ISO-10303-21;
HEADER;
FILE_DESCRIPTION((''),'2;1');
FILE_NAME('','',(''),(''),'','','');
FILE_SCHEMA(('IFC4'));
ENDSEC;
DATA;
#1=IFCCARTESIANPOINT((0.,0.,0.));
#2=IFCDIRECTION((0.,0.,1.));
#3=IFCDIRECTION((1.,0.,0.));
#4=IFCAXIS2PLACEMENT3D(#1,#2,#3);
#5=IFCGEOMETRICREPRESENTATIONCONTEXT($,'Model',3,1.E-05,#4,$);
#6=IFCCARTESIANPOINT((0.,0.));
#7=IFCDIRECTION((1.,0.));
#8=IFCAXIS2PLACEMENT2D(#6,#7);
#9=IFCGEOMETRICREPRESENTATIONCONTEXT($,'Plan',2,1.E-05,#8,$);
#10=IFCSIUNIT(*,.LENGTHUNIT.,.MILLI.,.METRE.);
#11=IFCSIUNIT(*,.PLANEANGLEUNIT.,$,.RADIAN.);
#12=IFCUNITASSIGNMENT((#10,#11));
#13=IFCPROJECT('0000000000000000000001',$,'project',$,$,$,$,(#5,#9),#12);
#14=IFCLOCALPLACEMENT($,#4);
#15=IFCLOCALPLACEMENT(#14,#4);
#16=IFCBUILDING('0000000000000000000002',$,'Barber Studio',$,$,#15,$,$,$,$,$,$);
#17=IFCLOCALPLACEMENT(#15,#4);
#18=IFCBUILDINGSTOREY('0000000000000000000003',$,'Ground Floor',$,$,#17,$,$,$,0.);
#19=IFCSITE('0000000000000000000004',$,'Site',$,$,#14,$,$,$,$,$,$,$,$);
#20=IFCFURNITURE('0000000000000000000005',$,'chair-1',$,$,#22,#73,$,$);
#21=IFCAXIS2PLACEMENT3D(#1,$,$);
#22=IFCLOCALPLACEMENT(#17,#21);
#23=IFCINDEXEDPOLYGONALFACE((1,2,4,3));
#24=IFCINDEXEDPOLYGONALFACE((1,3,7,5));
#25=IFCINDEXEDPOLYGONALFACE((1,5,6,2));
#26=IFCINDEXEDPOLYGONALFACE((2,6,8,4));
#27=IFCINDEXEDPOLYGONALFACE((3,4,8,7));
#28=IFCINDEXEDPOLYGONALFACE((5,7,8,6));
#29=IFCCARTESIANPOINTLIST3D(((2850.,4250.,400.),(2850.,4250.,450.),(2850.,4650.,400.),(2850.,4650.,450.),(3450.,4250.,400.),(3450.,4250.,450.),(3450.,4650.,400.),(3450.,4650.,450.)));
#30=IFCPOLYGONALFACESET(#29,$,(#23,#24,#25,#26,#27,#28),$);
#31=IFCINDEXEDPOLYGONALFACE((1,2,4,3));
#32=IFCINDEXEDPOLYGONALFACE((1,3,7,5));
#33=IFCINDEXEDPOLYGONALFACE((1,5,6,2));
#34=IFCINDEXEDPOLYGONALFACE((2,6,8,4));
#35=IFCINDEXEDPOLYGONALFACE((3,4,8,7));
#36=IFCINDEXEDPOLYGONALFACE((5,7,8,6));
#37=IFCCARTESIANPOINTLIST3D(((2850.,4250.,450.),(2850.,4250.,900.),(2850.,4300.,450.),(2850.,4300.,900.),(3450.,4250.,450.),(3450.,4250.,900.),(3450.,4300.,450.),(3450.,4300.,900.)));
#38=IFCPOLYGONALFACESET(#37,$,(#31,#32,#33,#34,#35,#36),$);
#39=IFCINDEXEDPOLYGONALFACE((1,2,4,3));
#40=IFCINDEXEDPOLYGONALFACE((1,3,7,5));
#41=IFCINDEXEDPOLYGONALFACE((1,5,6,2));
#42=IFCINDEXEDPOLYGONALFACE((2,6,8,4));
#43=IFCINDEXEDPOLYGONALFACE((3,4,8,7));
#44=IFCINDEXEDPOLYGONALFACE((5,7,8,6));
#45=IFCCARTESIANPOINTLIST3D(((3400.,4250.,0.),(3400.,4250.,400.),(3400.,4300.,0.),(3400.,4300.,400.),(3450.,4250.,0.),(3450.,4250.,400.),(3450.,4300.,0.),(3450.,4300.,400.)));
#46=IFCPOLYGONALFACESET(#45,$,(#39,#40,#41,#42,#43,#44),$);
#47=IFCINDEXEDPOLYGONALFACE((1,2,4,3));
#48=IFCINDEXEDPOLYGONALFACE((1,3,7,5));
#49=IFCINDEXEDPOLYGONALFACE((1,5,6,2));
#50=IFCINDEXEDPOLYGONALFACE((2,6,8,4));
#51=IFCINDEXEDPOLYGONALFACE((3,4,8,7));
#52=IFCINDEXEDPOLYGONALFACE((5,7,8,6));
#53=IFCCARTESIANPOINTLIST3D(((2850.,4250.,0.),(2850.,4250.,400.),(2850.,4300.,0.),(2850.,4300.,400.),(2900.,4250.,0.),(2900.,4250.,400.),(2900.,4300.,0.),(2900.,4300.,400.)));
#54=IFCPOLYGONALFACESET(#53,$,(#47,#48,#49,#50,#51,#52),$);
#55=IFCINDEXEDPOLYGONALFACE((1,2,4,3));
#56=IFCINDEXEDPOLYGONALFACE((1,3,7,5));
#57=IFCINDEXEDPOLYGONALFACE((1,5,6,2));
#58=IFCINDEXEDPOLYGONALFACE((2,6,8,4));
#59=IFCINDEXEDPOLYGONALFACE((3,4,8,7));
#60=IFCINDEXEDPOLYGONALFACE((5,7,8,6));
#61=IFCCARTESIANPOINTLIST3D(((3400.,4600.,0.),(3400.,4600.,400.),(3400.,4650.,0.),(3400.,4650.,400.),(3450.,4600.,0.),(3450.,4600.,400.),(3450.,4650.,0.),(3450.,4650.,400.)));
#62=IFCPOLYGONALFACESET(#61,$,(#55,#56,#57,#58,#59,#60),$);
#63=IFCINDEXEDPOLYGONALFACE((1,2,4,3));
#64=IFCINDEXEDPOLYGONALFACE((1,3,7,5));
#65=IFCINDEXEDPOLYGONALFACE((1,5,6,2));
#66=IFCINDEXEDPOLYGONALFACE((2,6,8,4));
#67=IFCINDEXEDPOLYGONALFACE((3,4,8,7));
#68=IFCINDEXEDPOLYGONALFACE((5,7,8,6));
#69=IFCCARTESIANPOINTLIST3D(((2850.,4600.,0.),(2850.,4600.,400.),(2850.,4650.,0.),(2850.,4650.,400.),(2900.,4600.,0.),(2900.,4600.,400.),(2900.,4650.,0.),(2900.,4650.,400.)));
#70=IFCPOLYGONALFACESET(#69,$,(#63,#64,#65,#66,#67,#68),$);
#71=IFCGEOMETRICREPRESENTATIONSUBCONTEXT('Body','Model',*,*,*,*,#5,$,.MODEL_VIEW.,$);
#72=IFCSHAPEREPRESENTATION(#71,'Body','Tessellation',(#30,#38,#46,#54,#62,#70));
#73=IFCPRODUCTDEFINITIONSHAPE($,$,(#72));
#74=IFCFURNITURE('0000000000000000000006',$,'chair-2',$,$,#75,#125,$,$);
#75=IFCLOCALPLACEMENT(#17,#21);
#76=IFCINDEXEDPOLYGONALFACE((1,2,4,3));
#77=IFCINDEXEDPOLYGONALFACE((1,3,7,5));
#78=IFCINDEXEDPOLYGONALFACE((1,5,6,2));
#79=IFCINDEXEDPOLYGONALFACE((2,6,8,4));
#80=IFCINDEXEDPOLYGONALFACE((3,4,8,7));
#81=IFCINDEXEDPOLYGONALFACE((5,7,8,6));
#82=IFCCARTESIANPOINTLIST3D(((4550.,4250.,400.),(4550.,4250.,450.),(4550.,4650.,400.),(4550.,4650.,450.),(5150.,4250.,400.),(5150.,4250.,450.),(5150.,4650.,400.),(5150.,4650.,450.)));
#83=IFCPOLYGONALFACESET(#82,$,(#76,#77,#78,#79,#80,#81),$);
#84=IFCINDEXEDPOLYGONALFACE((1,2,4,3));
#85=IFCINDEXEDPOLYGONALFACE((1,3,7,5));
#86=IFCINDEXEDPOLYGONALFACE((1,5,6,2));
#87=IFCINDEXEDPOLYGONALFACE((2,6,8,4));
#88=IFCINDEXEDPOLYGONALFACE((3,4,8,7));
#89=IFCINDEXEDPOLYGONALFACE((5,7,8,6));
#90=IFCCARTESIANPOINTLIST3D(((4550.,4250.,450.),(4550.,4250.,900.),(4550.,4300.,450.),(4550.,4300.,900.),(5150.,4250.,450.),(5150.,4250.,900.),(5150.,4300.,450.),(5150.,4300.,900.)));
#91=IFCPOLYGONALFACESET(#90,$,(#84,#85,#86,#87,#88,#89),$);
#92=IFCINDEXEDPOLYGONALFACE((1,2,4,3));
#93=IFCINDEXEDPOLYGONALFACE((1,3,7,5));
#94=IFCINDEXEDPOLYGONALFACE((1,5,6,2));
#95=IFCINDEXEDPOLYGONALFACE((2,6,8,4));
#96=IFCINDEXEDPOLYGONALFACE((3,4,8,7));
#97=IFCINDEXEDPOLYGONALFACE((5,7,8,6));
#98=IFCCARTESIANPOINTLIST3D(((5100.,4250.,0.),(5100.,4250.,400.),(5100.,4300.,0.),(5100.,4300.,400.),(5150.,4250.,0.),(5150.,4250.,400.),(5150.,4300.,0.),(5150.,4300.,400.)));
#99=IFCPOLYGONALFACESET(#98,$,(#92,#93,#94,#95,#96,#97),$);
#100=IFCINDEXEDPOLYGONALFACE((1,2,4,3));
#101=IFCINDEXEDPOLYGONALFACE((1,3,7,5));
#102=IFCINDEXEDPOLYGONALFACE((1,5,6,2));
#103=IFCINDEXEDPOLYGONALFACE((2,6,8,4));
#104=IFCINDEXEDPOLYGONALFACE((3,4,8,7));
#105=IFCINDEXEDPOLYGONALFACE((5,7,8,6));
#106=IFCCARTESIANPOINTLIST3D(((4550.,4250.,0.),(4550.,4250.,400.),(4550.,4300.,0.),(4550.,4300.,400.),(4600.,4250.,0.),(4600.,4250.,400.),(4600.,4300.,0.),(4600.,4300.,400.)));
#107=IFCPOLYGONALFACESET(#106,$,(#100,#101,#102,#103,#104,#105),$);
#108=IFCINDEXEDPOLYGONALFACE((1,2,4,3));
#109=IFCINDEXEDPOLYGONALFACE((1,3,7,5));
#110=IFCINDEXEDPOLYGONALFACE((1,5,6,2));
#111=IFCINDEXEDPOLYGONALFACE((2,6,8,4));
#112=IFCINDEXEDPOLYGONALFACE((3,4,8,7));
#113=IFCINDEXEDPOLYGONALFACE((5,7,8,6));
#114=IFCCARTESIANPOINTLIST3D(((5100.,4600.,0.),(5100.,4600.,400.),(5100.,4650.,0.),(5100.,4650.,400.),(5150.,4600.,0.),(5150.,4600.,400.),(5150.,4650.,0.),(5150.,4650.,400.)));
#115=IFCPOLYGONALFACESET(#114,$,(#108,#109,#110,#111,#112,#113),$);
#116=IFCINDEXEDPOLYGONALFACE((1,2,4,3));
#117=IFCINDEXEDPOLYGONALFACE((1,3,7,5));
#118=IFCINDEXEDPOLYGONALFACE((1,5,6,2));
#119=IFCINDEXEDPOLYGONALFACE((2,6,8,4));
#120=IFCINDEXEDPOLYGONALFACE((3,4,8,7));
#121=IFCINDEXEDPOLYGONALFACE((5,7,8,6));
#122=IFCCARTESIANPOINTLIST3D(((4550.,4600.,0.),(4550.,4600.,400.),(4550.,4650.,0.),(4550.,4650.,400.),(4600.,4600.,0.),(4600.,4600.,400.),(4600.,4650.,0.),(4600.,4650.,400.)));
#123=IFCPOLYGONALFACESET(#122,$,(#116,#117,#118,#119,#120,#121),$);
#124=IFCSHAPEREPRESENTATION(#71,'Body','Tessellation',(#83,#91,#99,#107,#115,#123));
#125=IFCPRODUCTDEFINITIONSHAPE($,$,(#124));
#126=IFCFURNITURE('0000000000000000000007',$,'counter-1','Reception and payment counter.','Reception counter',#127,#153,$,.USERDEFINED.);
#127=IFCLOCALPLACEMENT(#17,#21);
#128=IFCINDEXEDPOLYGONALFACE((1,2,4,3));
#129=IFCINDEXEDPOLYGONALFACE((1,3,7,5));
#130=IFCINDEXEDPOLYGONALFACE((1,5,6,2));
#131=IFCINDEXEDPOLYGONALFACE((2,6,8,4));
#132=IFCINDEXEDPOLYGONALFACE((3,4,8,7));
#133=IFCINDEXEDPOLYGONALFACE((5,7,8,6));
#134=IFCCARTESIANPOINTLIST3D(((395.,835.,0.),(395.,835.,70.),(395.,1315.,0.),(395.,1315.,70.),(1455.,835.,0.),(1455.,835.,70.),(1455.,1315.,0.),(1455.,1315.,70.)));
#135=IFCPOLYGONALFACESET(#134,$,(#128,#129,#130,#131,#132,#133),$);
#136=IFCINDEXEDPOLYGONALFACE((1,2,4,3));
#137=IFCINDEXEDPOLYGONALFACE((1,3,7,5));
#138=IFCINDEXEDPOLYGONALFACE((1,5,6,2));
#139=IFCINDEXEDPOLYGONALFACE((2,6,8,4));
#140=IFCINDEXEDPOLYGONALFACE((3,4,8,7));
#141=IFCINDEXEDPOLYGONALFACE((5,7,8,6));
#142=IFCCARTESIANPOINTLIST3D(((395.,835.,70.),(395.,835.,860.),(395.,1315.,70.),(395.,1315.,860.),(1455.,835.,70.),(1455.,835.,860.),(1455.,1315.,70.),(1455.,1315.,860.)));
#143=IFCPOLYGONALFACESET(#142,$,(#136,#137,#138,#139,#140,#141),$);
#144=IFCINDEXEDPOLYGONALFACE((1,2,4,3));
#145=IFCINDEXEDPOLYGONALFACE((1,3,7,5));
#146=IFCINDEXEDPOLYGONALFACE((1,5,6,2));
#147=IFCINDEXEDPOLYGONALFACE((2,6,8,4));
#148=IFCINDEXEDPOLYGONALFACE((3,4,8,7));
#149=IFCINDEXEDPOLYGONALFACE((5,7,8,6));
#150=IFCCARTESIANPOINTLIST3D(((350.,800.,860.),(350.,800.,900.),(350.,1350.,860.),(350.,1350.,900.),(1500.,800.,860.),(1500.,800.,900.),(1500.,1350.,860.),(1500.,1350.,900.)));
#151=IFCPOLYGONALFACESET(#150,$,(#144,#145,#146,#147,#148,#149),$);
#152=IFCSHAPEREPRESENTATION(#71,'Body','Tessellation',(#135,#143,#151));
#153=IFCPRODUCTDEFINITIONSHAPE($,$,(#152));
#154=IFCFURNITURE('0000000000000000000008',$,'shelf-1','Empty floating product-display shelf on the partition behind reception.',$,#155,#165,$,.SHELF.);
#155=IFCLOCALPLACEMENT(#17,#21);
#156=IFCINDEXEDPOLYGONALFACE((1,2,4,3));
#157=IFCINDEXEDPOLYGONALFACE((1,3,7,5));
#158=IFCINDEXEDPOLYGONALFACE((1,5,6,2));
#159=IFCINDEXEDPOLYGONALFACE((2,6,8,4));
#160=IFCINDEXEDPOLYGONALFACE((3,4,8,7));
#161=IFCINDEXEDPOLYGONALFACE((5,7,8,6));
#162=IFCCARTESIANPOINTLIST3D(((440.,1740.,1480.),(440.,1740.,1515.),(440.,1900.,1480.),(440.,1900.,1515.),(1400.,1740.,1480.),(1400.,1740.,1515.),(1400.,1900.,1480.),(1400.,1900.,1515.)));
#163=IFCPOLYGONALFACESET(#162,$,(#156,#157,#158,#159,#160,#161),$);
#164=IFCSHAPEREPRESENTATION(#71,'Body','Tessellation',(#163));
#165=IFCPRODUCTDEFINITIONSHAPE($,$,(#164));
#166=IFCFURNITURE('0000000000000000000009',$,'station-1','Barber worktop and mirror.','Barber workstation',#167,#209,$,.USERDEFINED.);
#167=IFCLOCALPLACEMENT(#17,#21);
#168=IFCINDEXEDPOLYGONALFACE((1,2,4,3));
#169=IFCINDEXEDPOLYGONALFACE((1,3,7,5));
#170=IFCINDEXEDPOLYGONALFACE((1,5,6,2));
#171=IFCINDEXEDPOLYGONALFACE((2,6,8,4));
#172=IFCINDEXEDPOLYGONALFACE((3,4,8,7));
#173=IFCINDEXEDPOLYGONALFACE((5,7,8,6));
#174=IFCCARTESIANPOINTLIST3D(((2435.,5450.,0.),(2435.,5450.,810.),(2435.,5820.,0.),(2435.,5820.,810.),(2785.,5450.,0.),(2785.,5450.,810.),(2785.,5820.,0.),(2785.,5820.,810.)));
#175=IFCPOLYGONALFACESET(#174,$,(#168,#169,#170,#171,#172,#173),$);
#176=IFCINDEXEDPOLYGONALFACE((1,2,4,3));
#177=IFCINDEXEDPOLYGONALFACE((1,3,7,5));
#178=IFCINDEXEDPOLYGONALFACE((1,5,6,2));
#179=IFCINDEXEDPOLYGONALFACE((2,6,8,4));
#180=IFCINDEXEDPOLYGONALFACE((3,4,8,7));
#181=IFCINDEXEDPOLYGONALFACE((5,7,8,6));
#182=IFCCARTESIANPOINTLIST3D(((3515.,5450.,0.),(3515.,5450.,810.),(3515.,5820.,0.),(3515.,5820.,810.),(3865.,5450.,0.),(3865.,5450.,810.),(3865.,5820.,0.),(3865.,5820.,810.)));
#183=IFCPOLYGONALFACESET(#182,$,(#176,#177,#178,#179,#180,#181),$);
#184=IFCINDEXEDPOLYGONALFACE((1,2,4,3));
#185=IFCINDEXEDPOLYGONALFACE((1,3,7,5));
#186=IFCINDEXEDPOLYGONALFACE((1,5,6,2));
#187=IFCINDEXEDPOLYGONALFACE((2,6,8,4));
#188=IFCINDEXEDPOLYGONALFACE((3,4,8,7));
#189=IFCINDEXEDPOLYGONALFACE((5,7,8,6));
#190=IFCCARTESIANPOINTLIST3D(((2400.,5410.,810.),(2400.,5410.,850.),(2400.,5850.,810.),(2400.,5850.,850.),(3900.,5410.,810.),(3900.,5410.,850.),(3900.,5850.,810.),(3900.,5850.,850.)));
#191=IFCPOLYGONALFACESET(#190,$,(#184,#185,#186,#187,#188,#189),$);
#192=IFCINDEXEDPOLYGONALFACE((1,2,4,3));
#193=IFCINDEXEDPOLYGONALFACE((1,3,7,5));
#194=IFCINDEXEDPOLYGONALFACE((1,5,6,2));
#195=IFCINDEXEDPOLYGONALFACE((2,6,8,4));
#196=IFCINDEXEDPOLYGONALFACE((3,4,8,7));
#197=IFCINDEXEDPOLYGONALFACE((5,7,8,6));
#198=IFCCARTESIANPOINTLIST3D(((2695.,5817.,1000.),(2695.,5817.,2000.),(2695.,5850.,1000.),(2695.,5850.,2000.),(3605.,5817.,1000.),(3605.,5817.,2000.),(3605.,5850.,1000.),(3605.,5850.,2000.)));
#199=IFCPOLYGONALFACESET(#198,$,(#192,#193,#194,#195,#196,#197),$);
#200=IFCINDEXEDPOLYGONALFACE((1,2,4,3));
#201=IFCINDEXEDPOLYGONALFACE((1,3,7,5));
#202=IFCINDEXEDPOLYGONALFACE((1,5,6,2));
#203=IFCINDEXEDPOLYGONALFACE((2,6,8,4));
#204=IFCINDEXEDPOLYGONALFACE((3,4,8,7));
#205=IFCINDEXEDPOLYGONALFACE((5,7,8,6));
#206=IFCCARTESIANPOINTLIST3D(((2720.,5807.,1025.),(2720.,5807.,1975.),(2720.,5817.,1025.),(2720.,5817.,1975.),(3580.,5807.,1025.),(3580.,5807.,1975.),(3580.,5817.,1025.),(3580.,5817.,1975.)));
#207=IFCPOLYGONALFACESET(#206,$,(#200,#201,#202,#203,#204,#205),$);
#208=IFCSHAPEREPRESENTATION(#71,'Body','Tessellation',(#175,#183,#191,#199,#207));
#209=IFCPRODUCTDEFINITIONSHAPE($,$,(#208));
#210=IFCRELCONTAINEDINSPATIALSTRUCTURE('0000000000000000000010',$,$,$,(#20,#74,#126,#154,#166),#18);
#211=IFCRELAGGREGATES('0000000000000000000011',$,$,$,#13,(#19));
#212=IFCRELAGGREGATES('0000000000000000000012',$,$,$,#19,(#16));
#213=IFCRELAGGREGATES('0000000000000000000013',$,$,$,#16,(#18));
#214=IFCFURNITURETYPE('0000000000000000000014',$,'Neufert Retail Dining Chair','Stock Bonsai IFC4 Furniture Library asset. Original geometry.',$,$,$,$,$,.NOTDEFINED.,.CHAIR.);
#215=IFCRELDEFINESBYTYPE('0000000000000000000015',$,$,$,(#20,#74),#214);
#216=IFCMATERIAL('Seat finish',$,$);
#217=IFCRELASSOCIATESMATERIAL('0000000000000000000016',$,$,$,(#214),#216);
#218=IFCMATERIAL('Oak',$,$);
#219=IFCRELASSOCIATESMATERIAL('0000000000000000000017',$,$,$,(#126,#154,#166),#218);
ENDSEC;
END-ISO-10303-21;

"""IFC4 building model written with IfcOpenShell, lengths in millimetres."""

from ifc_helpers import new_model, entity, si_unit, frame, origin_with_axes, origin_2d_with_axis, place, context, subcontext, project, spatial, line, indexed_curve, outline, extrude, shape, source, transform, mapped, material, type_object, type_shapes, element, save


model = new_model("IFC4")

# Units and contexts
model_context = context("Model", 3, precision=1e-05, world=origin_with_axes())
plan_context = context("Plan", 2, precision=1e-05, world=origin_2d_with_axis())
body_context_1 = subcontext(model_context, "Body", "Model", "MODEL_VIEW")
body_context_2 = subcontext(plan_context, "Body", "Plan", "PLAN_VIEW")
ifc_project = project(units=[si_unit("LENGTHUNIT", "METRE", prefix="MILLI"), si_unit("PLANEANGLEUNIT", "RADIAN")], contexts=[model_context, plan_context])

# Site, building, storey
site_placement = place(None, origin_with_axes())
site = spatial("IfcSite", under=ifc_project, at=site_placement, Name="Site")
building_placement = place(site_placement, origin_with_axes())
building = spatial("IfcBuilding", under=site, at=building_placement, Name="Barber Studio")
storey_placement = place(building_placement, origin_with_axes())
storey = spatial("IfcBuildingStorey", under=building, at=storey_placement, Name="Ground Floor", Elevation=0.0)

# Furniture
ifc_material_1 = material(Name="Seat finish")
furniture_type_1 = type_object("IfcFurnitureType", Name="Neufert Retail Dining Chair", Description="Stock Bonsai IFC4 Furniture Library asset. Original geometry.", AssemblyPlace="NOTDEFINED", PredefinedType="CHAIR", material=ifc_material_1)
shared_shape_1 = source(origin_with_axes(), body_context_1, "Body", "SweptSolid", [
    extrude(outline(indexed_curve([(-300.0, 0.0), (300.0, 0.0), (300.0, -400.0), (-300.0, -400.0)], segments=[line(1, 2, 3, 4, 1)])), frame((0.0, 0.0, 450.0), z_axis=(0.0, 0.0, 1.0), x_axis=(1.0, 0.0, 0.0)), (0.0, 0.0, -1.0), 50.0),
    extrude(outline(indexed_curve([(-300.0, 0.0), (300.0, 0.0), (300.0, -50.0), (-300.0, -50.0)], segments=[line(1, 2, 3, 4, 1)])), frame((0.0, 0.0, 900.0), z_axis=(0.0, 0.0, 1.0), x_axis=(1.0, 0.0, 0.0)), (0.0, 0.0, -1.0), 450.0),
    extrude(outline(indexed_curve([(-300.0, 0.0), (-250.0, 0.0), (-250.0, -50.0), (-300.0, -50.0)], segments=[line(1, 2, 3, 4, 1)])), origin_with_axes(), (0.0, 0.0, 1.0), 400.0),
    extrude(outline(indexed_curve([(300.0, 0.0), (250.0, 0.0), (250.0, -50.0), (300.0, -50.0)], segments=[line(1, 2, 3, 4, 1)])), origin_with_axes(), (0.0, 0.0, 1.0), 400.0),
    extrude(outline(indexed_curve([(-300.0, -400.0), (-250.0, -400.0), (-250.0, -350.0), (-300.0, -350.0)], segments=[line(1, 2, 3, 4, 1)])), origin_with_axes(), (0.0, 0.0, 1.0), 400.0),
    extrude(outline(indexed_curve([(300.0, -400.0), (250.0, -400.0), (250.0, -350.0), (300.0, -350.0)], segments=[line(1, 2, 3, 4, 1)])), origin_with_axes(), (0.0, 0.0, 1.0), 400.0),
])
shared_shape_2 = source(origin_with_axes(), body_context_2, "Body", "Curve2D", [
    entity("IfcIndexedPolyCurve", entity("IfcCartesianPointList2D", [[-300.0, -400.0], [300.0, -400.0]])),
    entity("IfcIndexedPolyCurve", entity("IfcCartesianPointList2D", [[-300.0, -400.0], [-300.0, -300.0], [-212.1, -87.9], [0.0, 0.0], [212.1, -87.9], [300.0, -300.0], [300.0, -400.0]]), [entity("IfcLineIndex", [1, 2]), entity("IfcArcIndex", [2, 3, 4]), entity("IfcArcIndex", [4, 5, 6]), entity("IfcLineIndex", [6, 7])]),
    entity("IfcIndexedPolyCurve", entity("IfcCartesianPointList2D", [[-260.0, -400.0], [-260.0, -300.0], [-183.8, -116.2], [0.0, -40.0], [183.8, -116.2], [260.0, -300.0], [260.0, -400.0]]), [entity("IfcLineIndex", [1, 2]), entity("IfcArcIndex", [2, 3, 4]), entity("IfcArcIndex", [4, 5, 6]), entity("IfcLineIndex", [6, 7])]),
])
type_shapes(furniture_type_1, [shared_shape_1, shared_shape_2])
for number, where, z_axis, x_axis, name in (
    (1, (3150.0, 4250.0, 0.0), (0.0, 0.0, 1.0), (-1.0, 0.0, 0.0), "chair-1"),
    (2, (4850.0, 4250.0, 0.0), (0.0, 0.0, 1.0), (-1.0, 0.0, 0.0), "chair-2"),
):
    element("IfcFurniture", number, at=place(storey_placement, frame(where, z_axis=z_axis, x_axis=x_axis)), inside=storey, type_object=furniture_type_1, Name=name, shapes=[
        shape(body_context_1, "Body", "MappedRepresentation", [mapped(shared_shape_1, transform((0.0, 0.0, 0.0), x_axis=(1.0, 0.0, 0.0), y_axis=(0.0, 1.0, 0.0), z_axis=(0.0, 0.0, 1.0), scale=1.0))]),
        shape(body_context_2, "Body", "MappedRepresentation", [mapped(shared_shape_2, transform((0.0, 0.0, 0.0), x_axis=(1.0, 0.0, 0.0), y_axis=(0.0, 1.0, 0.0), z_axis=(0.0, 0.0, 1.0), scale=1.0))]),
    ])
ifc_material_2 = material(Name="Oak")
furniture_1_placement = place(storey_placement, frame((350.0, 800.0, 0.0), z_axis=(0.0, 0.0, 1.0), x_axis=(1.0, 0.0, 0.0)))
element("IfcFurniture", 3, at=furniture_1_placement, inside=storey, material=ifc_material_2, Name="counter-1", Description="Reception and payment counter.", ObjectType="Reception counter", PredefinedType="USERDEFINED", context=body_context_1, shape_type="SweptSolid", body=[
    extrude(outline(indexed_curve([(0.0, 0.0), (1060.0, 0.0), (1060.0, 480.0), (0.0, 480.0)], segments=[line(1, 2, 3, 4, 1)])), frame((45.0, 35.0, 0.0), z_axis=(0.0, 0.0, 1.0), x_axis=(1.0, 0.0, 0.0)), (0.0, 0.0, 1.0), 70.0),
    extrude(outline(indexed_curve([(0.0, 0.0), (1060.0, 0.0), (1060.0, 480.0), (0.0, 480.0)], segments=[line(1, 2, 3, 4, 1)])), frame((45.0, 35.0, 70.0), z_axis=(0.0, 0.0, 1.0), x_axis=(1.0, 0.0, 0.0)), (0.0, 0.0, 1.0), 790.0),
    extrude(outline(indexed_curve([(0.0, 0.0), (1150.0, 0.0), (1150.0, 550.0), (0.0, 550.0)], segments=[line(1, 2, 3, 4, 1)])), frame((0.0, 0.0, 860.0), z_axis=(0.0, 0.0, 1.0), x_axis=(1.0, 0.0, 0.0)), (0.0, 0.0, 1.0), 40.0),
])
furniture_2_placement = place(storey_placement, frame((440.0, 1740.0, 1480.0), z_axis=(0.0, 0.0, 1.0), x_axis=(1.0, 0.0, 0.0)))
element("IfcFurniture", 4, at=furniture_2_placement, inside=storey, material=ifc_material_2, Name="shelf-1", Description="Empty floating product-display shelf on the partition behind reception.", PredefinedType="SHELF", context=body_context_1, shape_type="SweptSolid", body=[
    extrude(outline(indexed_curve([(0.0, 0.0), (960.0, 0.0), (960.0, 160.0), (0.0, 160.0)], segments=[line(1, 2, 3, 4, 1)])), origin_with_axes(), (0.0, 0.0, 1.0), 35.0),
])
for number, where, z_axis, x_axis, name in (
    (5, (2400.0, 5410.0, 0.0), (0.0, 0.0, 1.0), (1.0, 0.0, 0.0), "station-1"),
):
    element("IfcFurniture", number, at=place(storey_placement, frame(where, z_axis=z_axis, x_axis=x_axis)), inside=storey, material=ifc_material_2, Name=name, Description="Barber worktop and mirror.", ObjectType="Barber workstation", PredefinedType="USERDEFINED", context=body_context_1, shape_type="SweptSolid", body=[
        extrude(outline(indexed_curve([(0.0, 0.0), (350.0, 0.0), (350.0, 370.0), (0.0, 370.0)], segments=[line(1, 2, 3, 4, 1)])), frame((35.0, 40.0, 0.0), z_axis=(0.0, 0.0, 1.0), x_axis=(1.0, 0.0, 0.0)), (0.0, 0.0, 1.0), 810.0),
        extrude(outline(indexed_curve([(0.0, 0.0), (350.0, 0.0), (350.0, 370.0), (0.0, 370.0)], segments=[line(1, 2, 3, 4, 1)])), frame((1115.0, 40.0, 0.0), z_axis=(0.0, 0.0, 1.0), x_axis=(1.0, 0.0, 0.0)), (0.0, 0.0, 1.0), 810.0),
        extrude(outline(indexed_curve([(0.0, 0.0), (1500.0, 0.0), (1500.0, 440.0), (0.0, 440.0)], segments=[line(1, 2, 3, 4, 1)])), frame((0.0, 0.0, 810.0), z_axis=(0.0, 0.0, 1.0), x_axis=(1.0, 0.0, 0.0)), (0.0, 0.0, 1.0), 40.0),
        extrude(outline(indexed_curve([(0.0, 0.0), (910.0, 0.0), (910.0, 33.0), (0.0, 33.0)], segments=[line(1, 2, 3, 4, 1)])), frame((295.0, 407.0, 1000.0), z_axis=(0.0, 0.0, 1.0), x_axis=(1.0, 0.0, 0.0)), (0.0, 0.0, 1.0), 1000.0),
        extrude(outline(indexed_curve([(0.0, 0.0), (860.0, 0.0), (860.0, 10.0), (0.0, 10.0)], segments=[line(1, 2, 3, 4, 1)])), frame((320.0, 397.0, 1025.0), z_axis=(0.0, 0.0, 1.0), x_axis=(1.0, 0.0, 0.0)), (0.0, 0.0, 1.0), 950.0),
    ])

save(model, "model.ifc")
